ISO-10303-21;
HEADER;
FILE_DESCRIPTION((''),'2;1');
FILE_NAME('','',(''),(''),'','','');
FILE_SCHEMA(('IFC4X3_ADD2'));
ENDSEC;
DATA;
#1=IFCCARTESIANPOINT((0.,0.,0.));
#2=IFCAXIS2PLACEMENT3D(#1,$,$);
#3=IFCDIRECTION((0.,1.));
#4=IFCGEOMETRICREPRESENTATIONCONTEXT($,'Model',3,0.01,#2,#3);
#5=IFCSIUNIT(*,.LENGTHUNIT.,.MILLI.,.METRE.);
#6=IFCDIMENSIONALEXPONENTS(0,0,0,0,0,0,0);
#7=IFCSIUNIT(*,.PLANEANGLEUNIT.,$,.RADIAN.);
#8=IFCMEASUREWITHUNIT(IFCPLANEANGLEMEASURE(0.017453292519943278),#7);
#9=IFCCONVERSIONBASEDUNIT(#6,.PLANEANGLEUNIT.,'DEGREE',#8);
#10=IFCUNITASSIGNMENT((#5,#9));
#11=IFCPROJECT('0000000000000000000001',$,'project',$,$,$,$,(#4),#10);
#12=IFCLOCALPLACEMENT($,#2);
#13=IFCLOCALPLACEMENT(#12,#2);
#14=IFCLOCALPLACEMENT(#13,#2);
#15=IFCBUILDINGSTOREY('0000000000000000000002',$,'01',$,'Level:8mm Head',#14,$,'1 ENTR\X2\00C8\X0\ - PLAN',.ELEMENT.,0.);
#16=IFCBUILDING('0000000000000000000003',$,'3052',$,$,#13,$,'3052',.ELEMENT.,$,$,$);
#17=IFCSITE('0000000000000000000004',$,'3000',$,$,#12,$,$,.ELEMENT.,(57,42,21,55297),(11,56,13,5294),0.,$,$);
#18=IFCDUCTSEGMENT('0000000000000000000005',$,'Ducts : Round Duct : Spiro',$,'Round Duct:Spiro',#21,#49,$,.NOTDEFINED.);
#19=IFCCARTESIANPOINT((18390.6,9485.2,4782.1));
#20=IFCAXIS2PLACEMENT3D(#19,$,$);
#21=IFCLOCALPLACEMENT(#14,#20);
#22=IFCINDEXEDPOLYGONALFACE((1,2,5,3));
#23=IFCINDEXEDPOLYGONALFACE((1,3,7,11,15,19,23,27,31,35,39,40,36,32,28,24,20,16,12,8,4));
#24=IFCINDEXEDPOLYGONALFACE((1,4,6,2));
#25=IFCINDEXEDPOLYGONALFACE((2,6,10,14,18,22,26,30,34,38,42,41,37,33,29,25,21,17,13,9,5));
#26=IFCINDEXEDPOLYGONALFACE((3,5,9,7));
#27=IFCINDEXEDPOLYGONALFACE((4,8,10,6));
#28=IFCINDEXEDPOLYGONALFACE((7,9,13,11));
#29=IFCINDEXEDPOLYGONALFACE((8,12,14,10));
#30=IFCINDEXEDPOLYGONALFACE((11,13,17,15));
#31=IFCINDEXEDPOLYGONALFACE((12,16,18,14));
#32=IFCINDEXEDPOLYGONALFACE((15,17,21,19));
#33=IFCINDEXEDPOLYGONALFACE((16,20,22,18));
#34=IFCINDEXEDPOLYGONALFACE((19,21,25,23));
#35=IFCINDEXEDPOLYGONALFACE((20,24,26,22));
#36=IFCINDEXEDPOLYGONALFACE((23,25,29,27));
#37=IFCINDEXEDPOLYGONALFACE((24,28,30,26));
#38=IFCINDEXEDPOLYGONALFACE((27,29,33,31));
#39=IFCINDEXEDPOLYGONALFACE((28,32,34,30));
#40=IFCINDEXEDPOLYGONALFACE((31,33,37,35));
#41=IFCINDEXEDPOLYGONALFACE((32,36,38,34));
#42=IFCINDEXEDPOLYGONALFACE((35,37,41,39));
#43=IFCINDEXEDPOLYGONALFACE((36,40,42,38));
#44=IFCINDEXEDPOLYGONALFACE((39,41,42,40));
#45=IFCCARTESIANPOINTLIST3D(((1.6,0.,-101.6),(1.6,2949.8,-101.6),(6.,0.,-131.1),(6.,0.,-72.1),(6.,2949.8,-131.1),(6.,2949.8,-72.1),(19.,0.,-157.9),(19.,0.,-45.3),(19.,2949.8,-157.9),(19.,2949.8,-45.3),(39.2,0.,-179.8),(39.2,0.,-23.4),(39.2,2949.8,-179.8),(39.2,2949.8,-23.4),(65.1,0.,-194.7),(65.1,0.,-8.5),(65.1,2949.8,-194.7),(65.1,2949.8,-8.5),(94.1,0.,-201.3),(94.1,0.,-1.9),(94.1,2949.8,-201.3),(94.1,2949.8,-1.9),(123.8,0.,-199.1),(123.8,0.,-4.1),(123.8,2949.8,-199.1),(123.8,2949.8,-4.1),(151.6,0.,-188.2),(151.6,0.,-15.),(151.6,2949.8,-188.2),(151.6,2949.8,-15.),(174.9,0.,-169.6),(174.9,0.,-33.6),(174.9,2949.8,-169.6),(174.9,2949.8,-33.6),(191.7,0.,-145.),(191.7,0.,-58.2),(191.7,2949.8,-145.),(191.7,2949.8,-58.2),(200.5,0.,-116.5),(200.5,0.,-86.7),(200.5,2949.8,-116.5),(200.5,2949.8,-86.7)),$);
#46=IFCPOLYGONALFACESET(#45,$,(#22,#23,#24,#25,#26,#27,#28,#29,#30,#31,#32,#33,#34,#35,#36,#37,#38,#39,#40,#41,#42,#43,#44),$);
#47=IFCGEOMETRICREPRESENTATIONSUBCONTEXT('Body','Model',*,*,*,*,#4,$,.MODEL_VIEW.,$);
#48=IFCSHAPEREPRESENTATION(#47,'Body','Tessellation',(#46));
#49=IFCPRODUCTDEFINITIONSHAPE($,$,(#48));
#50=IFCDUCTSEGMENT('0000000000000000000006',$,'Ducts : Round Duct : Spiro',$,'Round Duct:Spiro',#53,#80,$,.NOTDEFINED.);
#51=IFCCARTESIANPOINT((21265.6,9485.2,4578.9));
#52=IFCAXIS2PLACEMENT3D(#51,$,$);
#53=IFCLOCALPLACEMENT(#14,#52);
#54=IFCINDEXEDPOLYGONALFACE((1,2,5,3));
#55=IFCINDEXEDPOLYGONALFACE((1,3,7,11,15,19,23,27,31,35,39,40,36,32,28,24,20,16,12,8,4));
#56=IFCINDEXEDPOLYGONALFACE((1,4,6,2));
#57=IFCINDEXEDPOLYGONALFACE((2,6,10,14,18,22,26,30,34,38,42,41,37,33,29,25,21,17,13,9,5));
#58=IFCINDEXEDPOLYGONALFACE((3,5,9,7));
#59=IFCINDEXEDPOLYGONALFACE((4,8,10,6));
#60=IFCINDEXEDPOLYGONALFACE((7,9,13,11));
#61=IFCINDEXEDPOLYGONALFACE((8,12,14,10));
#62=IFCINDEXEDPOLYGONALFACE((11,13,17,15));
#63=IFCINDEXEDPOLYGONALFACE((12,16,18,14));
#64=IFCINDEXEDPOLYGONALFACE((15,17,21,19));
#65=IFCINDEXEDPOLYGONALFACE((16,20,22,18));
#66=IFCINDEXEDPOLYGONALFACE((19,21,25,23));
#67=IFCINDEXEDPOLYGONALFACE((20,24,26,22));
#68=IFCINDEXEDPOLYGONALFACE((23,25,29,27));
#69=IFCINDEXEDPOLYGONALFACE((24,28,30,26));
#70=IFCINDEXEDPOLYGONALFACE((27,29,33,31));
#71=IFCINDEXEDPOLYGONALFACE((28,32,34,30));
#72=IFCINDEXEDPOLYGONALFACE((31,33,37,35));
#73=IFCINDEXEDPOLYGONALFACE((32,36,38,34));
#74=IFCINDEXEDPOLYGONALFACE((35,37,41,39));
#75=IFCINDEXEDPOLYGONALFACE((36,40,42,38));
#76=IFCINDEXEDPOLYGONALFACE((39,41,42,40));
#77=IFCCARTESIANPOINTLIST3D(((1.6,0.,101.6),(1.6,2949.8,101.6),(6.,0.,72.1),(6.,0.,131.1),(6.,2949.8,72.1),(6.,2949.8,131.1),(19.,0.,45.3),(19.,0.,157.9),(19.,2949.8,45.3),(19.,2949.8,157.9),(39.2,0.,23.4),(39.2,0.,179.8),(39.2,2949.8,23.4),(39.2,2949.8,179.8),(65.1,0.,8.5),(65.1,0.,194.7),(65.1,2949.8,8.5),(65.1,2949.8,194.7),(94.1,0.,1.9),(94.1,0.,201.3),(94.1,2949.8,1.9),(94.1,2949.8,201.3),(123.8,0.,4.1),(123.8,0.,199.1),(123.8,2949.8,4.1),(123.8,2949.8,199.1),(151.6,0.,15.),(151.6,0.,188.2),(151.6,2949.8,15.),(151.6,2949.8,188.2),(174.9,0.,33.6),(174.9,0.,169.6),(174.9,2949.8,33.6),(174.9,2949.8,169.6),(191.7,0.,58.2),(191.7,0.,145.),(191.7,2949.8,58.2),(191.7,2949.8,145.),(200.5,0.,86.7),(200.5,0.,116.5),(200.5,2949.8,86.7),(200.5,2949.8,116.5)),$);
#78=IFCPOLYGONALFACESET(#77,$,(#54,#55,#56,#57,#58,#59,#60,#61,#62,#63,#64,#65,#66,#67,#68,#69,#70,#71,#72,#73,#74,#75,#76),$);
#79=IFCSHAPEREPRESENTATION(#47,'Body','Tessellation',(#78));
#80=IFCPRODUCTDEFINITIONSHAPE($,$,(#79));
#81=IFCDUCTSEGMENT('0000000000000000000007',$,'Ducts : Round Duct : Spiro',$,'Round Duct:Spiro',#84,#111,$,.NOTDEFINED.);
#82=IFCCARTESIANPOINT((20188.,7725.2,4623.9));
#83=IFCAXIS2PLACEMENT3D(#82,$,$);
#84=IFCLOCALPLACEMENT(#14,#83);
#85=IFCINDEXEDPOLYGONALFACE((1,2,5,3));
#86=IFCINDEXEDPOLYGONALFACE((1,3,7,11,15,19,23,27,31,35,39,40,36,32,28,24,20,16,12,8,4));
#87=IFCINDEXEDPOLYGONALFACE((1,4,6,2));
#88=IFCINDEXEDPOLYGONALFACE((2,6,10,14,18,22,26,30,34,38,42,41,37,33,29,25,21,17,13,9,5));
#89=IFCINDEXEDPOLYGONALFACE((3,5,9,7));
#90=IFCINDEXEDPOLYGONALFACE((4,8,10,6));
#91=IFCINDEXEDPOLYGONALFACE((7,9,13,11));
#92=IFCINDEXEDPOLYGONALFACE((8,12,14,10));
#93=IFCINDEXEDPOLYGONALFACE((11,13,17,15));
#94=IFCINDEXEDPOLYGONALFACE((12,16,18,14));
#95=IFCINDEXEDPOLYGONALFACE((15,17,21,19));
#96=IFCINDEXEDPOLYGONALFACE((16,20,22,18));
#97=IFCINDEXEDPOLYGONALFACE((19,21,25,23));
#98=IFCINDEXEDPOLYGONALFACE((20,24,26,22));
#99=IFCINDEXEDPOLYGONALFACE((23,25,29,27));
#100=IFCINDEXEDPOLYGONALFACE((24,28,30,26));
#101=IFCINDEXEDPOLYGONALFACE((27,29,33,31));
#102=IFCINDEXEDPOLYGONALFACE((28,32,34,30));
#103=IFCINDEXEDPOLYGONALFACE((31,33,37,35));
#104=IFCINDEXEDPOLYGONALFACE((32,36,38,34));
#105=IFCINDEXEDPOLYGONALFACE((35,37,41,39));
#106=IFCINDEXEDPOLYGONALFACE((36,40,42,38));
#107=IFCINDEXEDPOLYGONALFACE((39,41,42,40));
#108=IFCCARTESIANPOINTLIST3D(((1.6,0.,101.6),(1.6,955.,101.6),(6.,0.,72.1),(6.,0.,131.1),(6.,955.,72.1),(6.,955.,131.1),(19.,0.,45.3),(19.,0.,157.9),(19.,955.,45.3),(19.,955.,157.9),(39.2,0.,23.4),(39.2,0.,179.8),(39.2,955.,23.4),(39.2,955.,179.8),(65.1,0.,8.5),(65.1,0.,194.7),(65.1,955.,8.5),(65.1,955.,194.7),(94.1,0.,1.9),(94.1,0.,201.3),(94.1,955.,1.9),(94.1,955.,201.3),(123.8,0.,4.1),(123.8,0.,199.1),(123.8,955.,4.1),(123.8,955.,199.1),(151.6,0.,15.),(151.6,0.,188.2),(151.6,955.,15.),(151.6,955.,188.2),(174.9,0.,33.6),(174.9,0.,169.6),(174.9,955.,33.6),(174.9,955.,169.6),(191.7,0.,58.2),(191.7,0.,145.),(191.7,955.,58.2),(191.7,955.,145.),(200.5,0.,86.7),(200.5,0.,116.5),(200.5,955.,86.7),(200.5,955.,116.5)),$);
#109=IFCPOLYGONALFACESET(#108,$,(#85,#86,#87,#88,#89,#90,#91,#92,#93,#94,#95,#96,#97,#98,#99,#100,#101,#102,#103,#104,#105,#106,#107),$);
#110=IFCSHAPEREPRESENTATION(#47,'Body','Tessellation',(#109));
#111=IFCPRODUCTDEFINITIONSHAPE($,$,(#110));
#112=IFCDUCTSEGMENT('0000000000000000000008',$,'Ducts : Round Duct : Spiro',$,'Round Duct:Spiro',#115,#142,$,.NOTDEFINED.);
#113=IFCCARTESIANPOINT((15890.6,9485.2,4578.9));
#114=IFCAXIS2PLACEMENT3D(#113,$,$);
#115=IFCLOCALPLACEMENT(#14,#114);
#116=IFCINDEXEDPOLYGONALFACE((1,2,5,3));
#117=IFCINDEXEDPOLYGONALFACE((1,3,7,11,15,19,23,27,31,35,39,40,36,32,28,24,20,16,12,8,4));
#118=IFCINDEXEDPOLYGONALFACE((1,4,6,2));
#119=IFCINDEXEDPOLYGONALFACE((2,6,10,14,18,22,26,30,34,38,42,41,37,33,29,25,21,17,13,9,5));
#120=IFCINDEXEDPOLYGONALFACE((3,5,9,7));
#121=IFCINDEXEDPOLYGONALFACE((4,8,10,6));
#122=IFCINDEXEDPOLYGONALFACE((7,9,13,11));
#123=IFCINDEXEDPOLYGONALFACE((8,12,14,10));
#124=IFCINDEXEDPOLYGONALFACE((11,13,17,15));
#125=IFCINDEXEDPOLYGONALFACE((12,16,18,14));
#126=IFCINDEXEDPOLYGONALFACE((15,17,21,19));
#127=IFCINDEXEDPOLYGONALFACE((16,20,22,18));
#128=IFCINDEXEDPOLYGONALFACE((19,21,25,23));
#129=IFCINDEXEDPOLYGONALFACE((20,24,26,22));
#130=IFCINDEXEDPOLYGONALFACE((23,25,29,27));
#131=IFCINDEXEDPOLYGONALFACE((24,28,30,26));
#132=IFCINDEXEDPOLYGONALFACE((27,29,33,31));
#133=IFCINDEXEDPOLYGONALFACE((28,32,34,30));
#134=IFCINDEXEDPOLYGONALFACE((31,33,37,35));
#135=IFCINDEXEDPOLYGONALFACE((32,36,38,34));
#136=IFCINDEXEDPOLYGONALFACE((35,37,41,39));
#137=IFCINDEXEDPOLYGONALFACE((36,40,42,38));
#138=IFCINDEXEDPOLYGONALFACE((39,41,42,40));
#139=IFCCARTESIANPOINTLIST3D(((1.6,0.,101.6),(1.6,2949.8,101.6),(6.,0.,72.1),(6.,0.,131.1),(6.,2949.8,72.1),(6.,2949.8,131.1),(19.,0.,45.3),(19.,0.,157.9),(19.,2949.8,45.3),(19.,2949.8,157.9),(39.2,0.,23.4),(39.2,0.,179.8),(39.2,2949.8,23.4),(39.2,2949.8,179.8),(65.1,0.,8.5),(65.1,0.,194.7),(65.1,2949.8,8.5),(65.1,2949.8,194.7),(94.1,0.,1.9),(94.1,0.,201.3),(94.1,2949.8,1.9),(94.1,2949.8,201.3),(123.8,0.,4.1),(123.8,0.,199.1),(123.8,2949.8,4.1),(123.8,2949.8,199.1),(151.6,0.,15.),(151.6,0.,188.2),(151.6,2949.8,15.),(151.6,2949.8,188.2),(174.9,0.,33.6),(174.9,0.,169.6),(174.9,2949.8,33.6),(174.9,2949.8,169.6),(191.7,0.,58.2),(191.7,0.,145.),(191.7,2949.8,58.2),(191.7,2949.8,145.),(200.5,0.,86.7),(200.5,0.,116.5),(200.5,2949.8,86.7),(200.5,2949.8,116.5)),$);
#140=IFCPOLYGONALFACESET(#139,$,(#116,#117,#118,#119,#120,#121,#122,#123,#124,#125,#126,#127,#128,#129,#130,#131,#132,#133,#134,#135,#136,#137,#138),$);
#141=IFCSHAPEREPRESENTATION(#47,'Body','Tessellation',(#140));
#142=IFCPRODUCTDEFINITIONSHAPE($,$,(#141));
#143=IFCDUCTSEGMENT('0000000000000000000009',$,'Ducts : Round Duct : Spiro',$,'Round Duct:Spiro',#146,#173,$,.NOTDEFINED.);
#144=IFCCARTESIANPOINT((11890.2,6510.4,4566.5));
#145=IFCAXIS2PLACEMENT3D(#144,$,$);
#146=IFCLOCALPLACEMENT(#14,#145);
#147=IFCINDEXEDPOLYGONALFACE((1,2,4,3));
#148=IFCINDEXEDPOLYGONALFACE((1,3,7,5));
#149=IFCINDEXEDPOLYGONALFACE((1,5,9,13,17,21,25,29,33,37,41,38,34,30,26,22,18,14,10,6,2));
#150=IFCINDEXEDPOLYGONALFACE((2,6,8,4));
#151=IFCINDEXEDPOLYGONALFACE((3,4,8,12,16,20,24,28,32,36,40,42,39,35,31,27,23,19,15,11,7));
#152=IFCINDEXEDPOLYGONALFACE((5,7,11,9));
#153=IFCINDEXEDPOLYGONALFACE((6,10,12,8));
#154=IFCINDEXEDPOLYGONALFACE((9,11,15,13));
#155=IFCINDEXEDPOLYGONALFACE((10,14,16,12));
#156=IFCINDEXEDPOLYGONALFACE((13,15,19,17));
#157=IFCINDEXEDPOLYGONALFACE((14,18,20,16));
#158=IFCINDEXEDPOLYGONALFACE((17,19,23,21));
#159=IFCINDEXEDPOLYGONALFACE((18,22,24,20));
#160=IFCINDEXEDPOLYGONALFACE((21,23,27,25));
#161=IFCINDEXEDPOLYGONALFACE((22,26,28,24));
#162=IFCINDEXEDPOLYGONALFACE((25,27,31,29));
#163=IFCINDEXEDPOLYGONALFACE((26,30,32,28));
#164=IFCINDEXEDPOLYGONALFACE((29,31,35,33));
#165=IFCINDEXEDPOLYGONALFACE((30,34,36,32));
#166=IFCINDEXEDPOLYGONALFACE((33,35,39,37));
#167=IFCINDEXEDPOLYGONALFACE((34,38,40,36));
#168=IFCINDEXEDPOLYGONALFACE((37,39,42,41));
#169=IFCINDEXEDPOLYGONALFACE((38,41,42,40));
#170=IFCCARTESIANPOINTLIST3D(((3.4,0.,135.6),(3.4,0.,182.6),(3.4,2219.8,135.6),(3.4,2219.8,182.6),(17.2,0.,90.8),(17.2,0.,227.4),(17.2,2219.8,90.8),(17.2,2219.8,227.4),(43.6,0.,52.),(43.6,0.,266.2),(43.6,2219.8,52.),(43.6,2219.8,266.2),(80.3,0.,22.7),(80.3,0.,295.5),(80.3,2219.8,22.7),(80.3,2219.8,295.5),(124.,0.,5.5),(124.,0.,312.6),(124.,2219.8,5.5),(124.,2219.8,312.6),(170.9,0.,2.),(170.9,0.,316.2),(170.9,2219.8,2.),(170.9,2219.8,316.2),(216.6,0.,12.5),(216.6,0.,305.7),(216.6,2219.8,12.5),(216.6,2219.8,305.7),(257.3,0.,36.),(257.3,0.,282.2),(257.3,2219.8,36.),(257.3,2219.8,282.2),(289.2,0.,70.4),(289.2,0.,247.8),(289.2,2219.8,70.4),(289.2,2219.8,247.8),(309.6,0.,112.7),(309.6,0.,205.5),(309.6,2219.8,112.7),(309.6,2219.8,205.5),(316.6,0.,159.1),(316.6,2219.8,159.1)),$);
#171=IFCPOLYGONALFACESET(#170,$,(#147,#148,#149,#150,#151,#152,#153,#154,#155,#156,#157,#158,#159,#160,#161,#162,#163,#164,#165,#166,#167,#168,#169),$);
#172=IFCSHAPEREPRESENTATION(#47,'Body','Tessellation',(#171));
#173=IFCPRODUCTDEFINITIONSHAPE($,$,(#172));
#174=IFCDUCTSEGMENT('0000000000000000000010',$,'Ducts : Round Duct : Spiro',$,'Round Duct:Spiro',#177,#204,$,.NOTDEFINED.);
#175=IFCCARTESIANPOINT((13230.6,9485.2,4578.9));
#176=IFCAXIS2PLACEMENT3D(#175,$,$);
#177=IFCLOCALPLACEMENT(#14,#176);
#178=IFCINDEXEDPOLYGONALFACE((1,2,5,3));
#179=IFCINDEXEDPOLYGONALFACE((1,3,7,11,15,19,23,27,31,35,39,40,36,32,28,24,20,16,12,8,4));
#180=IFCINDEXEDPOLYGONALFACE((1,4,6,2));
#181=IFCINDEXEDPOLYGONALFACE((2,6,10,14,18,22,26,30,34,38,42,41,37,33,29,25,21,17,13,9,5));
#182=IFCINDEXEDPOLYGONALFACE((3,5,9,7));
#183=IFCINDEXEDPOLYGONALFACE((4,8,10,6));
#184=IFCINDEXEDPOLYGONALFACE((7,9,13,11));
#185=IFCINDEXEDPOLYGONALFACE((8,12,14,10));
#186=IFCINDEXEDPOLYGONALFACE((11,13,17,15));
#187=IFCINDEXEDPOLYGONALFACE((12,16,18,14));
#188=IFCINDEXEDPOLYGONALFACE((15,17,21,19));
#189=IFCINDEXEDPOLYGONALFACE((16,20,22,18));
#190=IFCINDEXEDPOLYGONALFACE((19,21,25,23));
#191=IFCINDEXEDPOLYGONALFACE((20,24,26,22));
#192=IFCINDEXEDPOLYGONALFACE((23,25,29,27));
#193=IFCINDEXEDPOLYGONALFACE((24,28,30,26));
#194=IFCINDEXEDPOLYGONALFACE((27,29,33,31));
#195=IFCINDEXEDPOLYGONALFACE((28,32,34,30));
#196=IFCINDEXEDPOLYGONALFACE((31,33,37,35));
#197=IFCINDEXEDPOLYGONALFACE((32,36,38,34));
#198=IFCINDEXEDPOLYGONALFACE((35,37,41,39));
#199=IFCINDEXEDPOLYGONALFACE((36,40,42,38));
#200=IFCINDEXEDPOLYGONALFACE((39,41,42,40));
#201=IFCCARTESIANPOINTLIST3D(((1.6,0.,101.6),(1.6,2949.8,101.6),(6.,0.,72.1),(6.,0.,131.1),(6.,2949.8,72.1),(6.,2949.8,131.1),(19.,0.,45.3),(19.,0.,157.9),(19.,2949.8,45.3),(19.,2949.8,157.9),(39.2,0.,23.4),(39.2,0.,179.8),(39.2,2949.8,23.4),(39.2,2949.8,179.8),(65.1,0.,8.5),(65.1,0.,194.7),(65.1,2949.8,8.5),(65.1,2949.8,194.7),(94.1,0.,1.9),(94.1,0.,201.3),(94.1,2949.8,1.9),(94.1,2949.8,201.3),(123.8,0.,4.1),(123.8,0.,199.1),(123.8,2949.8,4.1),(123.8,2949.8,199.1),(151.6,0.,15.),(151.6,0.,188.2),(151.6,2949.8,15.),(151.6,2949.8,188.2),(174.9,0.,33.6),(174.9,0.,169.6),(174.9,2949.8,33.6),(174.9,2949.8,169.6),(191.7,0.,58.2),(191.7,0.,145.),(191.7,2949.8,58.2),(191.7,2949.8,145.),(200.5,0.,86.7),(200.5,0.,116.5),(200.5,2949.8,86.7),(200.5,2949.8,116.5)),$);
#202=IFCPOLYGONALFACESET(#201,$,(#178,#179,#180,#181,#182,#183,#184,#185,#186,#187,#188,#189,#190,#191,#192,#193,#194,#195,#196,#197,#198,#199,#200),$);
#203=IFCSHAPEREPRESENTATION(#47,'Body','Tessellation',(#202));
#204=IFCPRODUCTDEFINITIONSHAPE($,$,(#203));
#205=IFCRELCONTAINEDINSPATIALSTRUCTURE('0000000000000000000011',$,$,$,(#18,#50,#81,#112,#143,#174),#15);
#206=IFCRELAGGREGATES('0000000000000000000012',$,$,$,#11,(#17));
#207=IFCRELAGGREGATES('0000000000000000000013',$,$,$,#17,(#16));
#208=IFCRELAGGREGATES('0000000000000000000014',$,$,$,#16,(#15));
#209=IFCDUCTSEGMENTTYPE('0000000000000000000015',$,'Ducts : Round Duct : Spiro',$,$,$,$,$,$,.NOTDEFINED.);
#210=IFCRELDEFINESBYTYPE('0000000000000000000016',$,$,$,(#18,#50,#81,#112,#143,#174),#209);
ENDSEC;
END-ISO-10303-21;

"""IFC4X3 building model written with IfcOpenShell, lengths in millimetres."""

from ifc_helpers import new_model, entity, si_unit, converted_unit, direction, frame, frame_2d, origin, origin_2d_with_axis, place, context, subcontext, project, spatial, circle, extrude, type_object, element, save


model = new_model("IFC4X3")

# Units and contexts
model_context = context("Model", 3, precision=0.01, world=origin(), true_north=direction((0.0, 1.0)))
body_context = subcontext(model_context, "Body", "Model", "MODEL_VIEW")
ifc_project = project(units=[si_unit("LENGTHUNIT", "METRE", prefix="MILLI"), converted_unit("PLANEANGLEUNIT", "DEGREE", entity("IfcPlaneAngleMeasure", 0.017453292519943278), si_unit("PLANEANGLEUNIT", "RADIAN"), dimensions=[0, 0, 0, 0, 0, 0, 0])], contexts=[model_context])

# Site, building, storey
site_placement = place(None, origin())
site = spatial("IfcSite", under=ifc_project, at=site_placement, Name="3000", CompositionType="ELEMENT", RefLatitude=(57, 42, 21, 55297), RefLongitude=(11, 56, 13, 5294), RefElevation=0.0)
building_placement = place(site_placement, origin())
building = spatial("IfcBuilding", under=site, at=building_placement, Name="3052", LongName="3052", CompositionType="ELEMENT")
storey_placement = place(building_placement, origin())
storey = spatial("IfcBuildingStorey", under=building, at=storey_placement, Name="01", ObjectType="Level:8mm Head", LongName="1 ENTRÈ - PLAN", CompositionType="ELEMENT", Elevation=0.0)

# Duct segments
duct_segment_type = type_object("IfcDuctSegmentType", Name="Ducts : Round Duct : Spiro", PredefinedType="NOTDEFINED")
duct_segment_1_placement = place(storey_placement, frame((18390.6, 9485.2, 4782.1)))
element("IfcDuctSegment", 1, at=duct_segment_1_placement, inside=storey, type_object=duct_segment_type, Name="Ducts : Round Duct : Spiro", ObjectType="Round Duct:Spiro", PredefinedType="NOTDEFINED", context=body_context, shape_type="SweptSolid", body=[
    extrude(circle(Radius=100.0, at=frame_2d((0.0, 0.0), x_axis=(1.0, 0.0))), frame((101.6, 0.0, -101.6), z_axis=(0.0, 1.0, 0.0), x_axis=(-1.0, 0.0, 0.0)), (0.0, 0.0, 1.0), 2949.8),
])
duct_segment_2_placement = place(storey_placement, frame((21265.6, 9485.2, 4578.9)))
element("IfcDuctSegment", 2, at=duct_segment_2_placement, inside=storey, type_object=duct_segment_type, Name="Ducts : Round Duct : Spiro", ObjectType="Round Duct:Spiro", PredefinedType="NOTDEFINED", context=body_context, shape_type="SweptSolid", body=[
    extrude(circle(Radius=100.0, at=origin_2d_with_axis()), frame((101.6, 0.0, 101.6), z_axis=(0.0, 1.0, 0.0), x_axis=(-1.0, 0.0, 0.0)), (0.0, 0.0, 1.0), 2949.8),
])
duct_segment_3_placement = place(storey_placement, frame((20188.0, 7725.2, 4623.9)))
element("IfcDuctSegment", 3, at=duct_segment_3_placement, inside=storey, type_object=duct_segment_type, Name="Ducts : Round Duct : Spiro", ObjectType="Round Duct:Spiro", PredefinedType="NOTDEFINED", context=body_context, shape_type="SweptSolid", body=[
    extrude(circle(Radius=100.0, at=origin_2d_with_axis()), frame((101.6, 0.0, 101.6), z_axis=(0.0, 1.0, 0.0), x_axis=(-1.0, 0.0, 0.0)), (0.0, 0.0, 1.0), 955.0),
])
duct_segment_4_placement = place(storey_placement, frame((15890.6, 9485.2, 4578.9)))
element("IfcDuctSegment", 4, at=duct_segment_4_placement, inside=storey, type_object=duct_segment_type, Name="Ducts : Round Duct : Spiro", ObjectType="Round Duct:Spiro", PredefinedType="NOTDEFINED", context=body_context, shape_type="SweptSolid", body=[
    extrude(circle(Radius=100.0, at=origin_2d_with_axis()), frame((101.6, 0.0, 101.6), z_axis=(0.0, 1.0, 0.0), x_axis=(-1.0, 0.0, 0.0)), (0.0, 0.0, 1.0), 2949.8),
])
duct_segment_5_placement = place(storey_placement, frame((11890.2, 6510.4, 4566.5)))
element("IfcDuctSegment", 5, at=duct_segment_5_placement, inside=storey, type_object=duct_segment_type, Name="Ducts : Round Duct : Spiro", ObjectType="Round Duct:Spiro", PredefinedType="NOTDEFINED", context=body_context, shape_type="SweptSolid", body=[
    extrude(circle(Radius=157.5, at=frame_2d((0.0, 0.0), x_axis=(1.0, 0.0))), frame((159.1, 0.0, 159.1), z_axis=(0.0, 1.0, 0.0), x_axis=(1.0, 0.0, 0.0)), (0.0, 0.0, 1.0), 2219.8),
])
duct_segment_6_placement = place(storey_placement, frame((13230.6, 9485.2, 4578.9)))
element("IfcDuctSegment", 6, at=duct_segment_6_placement, inside=storey, type_object=duct_segment_type, Name="Ducts : Round Duct : Spiro", ObjectType="Round Duct:Spiro", PredefinedType="NOTDEFINED", context=body_context, shape_type="SweptSolid", body=[
    extrude(circle(Radius=100.0, at=origin_2d_with_axis()), frame((101.6, 0.0, 101.6), z_axis=(0.0, 1.0, 0.0), x_axis=(-1.0, 0.0, 0.0)), (0.0, 0.0, 1.0), 2949.8),
])

save(model, "model.ifc")
